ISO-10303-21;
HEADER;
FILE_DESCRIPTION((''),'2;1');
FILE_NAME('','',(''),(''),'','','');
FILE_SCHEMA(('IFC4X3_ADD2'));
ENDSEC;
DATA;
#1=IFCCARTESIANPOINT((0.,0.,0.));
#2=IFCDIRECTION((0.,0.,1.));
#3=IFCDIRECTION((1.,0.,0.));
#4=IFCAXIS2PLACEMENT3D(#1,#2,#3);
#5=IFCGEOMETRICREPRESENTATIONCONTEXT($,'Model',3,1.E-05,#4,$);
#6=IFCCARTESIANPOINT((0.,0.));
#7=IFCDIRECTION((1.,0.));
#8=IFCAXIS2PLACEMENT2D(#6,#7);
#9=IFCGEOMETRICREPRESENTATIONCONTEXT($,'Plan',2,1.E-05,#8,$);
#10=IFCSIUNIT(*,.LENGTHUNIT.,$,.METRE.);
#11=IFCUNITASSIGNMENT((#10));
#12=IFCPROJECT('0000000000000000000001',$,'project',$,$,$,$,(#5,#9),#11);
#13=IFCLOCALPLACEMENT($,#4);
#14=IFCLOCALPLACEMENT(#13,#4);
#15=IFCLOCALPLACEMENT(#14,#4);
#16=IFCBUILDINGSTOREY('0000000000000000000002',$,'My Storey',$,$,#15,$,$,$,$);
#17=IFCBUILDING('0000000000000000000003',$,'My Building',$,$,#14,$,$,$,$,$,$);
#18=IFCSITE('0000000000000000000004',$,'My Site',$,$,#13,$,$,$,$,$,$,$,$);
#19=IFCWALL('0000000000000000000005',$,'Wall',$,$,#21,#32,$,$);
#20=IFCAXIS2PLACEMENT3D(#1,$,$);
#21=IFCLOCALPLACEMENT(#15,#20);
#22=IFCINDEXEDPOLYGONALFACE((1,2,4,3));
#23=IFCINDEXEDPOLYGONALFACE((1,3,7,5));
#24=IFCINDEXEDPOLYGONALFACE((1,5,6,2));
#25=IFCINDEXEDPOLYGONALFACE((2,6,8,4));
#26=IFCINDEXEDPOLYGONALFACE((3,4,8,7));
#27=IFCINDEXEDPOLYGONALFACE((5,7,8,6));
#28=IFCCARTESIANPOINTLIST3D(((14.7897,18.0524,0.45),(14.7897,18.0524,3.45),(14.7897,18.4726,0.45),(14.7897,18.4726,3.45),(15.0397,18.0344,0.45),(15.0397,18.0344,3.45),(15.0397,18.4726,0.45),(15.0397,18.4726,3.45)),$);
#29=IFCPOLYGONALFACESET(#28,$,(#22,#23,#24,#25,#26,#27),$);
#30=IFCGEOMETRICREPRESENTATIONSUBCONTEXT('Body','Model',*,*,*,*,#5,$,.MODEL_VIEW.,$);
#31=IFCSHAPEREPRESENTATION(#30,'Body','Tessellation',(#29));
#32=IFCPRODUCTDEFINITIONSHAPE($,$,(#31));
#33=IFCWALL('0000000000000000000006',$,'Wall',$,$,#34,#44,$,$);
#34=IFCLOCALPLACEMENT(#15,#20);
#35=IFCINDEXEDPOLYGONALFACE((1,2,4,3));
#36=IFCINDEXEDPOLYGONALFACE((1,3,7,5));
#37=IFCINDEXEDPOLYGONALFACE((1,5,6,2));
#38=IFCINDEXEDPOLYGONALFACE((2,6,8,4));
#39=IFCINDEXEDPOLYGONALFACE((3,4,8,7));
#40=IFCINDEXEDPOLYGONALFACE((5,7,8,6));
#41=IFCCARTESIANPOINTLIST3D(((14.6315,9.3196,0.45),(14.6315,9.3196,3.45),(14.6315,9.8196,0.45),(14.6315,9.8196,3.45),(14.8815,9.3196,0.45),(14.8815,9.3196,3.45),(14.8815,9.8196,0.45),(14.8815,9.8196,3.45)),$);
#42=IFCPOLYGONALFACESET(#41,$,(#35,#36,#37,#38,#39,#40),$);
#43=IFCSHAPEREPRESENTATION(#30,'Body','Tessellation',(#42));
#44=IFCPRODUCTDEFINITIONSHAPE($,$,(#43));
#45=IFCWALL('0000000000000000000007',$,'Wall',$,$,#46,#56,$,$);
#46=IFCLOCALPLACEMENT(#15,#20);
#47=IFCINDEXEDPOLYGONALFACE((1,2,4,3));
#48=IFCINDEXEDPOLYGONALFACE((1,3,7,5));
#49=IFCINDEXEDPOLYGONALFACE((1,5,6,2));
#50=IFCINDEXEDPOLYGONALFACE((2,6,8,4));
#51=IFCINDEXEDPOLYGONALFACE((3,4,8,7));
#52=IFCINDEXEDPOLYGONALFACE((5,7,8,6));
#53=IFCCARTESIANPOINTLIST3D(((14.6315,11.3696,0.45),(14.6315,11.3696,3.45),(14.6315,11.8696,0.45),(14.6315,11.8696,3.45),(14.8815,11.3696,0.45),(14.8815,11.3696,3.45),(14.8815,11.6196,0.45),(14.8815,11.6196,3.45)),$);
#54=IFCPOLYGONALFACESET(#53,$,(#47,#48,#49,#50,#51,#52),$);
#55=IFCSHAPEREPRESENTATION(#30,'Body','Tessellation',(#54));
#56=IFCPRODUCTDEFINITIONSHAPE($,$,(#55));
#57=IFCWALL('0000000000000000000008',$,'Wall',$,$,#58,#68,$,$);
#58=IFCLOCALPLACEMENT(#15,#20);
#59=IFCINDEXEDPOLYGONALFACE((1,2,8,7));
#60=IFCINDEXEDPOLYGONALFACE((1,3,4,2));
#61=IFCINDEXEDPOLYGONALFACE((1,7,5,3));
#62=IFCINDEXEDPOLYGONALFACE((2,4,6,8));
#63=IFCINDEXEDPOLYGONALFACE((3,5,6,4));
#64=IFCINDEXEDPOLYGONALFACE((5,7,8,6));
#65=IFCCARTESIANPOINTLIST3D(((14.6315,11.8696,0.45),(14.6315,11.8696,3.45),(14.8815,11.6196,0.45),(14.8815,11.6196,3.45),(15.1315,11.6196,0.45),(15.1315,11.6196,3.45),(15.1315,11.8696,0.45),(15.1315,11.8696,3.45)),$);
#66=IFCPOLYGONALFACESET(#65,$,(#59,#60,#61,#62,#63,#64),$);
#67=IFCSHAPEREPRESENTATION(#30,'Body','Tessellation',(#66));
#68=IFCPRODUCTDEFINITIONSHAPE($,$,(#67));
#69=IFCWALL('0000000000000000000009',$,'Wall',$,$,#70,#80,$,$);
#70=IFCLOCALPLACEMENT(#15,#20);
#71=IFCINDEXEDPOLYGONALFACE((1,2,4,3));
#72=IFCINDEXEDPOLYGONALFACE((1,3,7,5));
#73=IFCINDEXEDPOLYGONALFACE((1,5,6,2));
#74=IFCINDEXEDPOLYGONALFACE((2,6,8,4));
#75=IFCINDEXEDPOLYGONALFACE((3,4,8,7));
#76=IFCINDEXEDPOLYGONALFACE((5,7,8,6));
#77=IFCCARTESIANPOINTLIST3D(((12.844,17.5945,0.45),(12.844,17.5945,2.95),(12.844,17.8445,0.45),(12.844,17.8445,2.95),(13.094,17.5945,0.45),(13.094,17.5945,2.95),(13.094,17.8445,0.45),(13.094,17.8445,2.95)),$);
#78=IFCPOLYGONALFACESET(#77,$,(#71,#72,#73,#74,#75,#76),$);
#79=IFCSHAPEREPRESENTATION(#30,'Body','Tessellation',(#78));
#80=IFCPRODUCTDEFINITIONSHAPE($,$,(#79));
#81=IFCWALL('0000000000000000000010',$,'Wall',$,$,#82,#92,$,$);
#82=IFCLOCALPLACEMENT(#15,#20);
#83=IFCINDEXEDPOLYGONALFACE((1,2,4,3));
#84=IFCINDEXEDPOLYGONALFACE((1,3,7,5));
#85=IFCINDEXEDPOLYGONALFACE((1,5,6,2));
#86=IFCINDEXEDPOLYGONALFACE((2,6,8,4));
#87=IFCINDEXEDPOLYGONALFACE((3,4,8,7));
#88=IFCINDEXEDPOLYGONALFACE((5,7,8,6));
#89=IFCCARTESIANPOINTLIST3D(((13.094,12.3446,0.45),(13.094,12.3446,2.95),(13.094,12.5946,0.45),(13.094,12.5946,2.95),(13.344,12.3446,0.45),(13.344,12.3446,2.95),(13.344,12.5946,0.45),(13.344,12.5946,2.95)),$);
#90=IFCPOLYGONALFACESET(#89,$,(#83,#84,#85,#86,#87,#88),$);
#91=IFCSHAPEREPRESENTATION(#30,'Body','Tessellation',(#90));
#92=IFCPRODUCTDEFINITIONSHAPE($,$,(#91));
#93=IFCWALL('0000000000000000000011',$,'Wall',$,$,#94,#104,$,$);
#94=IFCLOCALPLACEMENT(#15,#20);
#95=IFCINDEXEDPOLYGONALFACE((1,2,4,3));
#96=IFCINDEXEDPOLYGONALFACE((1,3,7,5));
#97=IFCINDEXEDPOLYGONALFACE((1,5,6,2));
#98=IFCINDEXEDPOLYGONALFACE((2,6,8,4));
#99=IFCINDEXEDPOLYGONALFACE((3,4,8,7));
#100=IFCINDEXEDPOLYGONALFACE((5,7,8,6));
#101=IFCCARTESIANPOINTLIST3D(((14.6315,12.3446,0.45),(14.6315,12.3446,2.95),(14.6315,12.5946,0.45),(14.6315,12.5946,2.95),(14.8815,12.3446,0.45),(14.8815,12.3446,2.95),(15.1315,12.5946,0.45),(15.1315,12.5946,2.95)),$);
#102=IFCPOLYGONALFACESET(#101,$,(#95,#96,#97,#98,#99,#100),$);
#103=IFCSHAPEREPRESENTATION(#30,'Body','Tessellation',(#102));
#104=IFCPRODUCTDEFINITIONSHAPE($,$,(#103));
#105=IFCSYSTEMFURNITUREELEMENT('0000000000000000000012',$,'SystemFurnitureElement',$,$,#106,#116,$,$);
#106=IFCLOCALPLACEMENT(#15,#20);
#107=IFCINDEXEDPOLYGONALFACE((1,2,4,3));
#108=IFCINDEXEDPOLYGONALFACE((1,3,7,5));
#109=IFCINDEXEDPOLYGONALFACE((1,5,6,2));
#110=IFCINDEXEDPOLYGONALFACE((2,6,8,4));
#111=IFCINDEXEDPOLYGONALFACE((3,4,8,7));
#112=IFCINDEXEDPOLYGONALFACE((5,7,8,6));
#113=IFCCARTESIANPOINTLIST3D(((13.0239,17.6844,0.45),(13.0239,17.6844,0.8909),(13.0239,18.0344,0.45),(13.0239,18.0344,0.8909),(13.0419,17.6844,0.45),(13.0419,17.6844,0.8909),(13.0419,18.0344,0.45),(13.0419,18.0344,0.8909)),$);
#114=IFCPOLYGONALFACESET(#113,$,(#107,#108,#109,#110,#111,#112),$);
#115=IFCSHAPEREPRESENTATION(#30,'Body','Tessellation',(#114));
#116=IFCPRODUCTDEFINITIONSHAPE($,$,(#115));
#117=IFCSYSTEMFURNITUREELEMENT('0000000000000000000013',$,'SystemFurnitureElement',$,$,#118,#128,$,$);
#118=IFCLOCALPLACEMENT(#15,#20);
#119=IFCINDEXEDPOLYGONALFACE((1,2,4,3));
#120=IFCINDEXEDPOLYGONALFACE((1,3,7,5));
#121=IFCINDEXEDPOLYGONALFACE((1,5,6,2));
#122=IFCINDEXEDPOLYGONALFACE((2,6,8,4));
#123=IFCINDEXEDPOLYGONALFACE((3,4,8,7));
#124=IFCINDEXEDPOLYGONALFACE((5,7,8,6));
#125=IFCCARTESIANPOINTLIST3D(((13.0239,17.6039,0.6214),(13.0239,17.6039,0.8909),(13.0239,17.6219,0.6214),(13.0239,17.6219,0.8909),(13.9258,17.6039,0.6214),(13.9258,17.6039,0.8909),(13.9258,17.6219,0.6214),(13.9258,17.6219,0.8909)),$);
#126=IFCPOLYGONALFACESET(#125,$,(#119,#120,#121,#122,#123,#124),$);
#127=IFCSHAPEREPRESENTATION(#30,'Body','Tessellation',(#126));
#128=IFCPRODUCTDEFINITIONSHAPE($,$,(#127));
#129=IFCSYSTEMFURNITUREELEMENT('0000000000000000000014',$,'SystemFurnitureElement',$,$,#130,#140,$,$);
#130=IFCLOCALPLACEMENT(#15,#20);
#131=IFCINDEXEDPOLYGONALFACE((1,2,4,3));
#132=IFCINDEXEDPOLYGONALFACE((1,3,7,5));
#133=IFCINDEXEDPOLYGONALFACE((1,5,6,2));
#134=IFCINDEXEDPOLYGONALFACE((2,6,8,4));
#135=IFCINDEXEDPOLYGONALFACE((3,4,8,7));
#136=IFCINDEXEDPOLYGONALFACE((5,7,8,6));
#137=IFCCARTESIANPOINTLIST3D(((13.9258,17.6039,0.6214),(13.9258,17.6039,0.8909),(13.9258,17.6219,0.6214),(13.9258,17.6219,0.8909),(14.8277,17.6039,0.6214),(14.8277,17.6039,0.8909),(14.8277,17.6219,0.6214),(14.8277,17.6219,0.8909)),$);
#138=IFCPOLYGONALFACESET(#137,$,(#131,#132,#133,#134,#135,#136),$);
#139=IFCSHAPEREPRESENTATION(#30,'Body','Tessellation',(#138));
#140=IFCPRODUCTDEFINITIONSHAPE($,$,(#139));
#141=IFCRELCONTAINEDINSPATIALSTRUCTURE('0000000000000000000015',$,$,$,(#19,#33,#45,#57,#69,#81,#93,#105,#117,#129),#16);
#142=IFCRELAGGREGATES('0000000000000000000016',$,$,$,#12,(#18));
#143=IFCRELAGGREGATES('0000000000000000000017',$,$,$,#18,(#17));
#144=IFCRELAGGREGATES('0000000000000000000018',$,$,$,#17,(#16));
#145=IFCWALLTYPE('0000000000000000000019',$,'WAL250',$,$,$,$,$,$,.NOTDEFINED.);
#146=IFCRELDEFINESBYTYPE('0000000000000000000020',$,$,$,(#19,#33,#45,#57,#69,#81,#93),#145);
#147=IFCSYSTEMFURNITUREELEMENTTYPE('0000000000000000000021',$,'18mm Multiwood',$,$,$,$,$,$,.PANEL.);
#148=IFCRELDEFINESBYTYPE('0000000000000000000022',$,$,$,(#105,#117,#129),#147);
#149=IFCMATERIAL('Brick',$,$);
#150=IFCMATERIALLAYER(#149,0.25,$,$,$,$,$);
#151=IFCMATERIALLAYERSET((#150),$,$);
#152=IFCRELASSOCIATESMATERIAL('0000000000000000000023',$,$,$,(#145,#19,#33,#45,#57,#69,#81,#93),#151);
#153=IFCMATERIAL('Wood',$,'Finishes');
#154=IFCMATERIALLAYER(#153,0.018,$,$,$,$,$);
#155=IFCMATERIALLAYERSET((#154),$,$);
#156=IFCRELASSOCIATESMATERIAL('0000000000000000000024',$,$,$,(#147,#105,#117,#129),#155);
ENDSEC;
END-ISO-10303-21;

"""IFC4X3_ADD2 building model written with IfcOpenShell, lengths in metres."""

from ifc_helpers import new_model, si_unit, frame, origin_with_axes, origin_2d_with_axis, place, context, subcontext, project, spatial, line, indexed_curve, outline, extrude, material, layer, layer_set, layer_usage, type_object, element, save


model = new_model("IFC4X3_ADD2")

# Units and contexts
model_context = context("Model", 3, precision=1e-05, world=origin_with_axes())
plan_context = context("Plan", 2, precision=1e-05, world=origin_2d_with_axis())
body_context_1 = subcontext(model_context, "Body", "Model", "MODEL_VIEW")
ifc_project = project(units=[si_unit("LENGTHUNIT", "METRE")], contexts=[model_context, plan_context])

# Site, building, storey
site_placement = place(None, origin_with_axes())
site = spatial("IfcSite", under=ifc_project, at=site_placement, Name="My Site")
building_placement = place(site_placement, origin_with_axes())
building = spatial("IfcBuilding", under=site, at=building_placement, Name="My Building")
storey_placement = place(building_placement, origin_with_axes())
storey = spatial("IfcBuildingStorey", under=building, at=storey_placement, Name="My Storey")

# Shared definitions
ifc_material_1 = material(Name="Brick")

# Shared definitions
ifc_layer_1 = layer(ifc_material_1, 0.25)
ifc_layer_set_1 = layer_set([ifc_layer_1])
wall_type_1 = type_object("IfcWallType", Name="WAL250", PredefinedType="NOTDEFINED", material=ifc_layer_set_1)

# Walls
ifc_layer_usage_1 = layer_usage(ifc_layer_set_1, "AXIS2", "NEGATIVE", 0.0)
wall_1_placement = place(storey_placement, frame((14.7897, 18.0344, 0.45), z_axis=(0.0, 0.0, 1.0), x_axis=(-0.000005, 1.0, 0.0)))
element("IfcWall", 1, at=wall_1_placement, inside=storey, type_object=wall_type_1, material=ifc_layer_usage_1, Name="Wall", context=body_context_1, shape_type="SweptSolid", body=[
    extrude(outline(indexed_curve([(0.0, -0.25), (0.018, 0.0), (0.4382, 0.0), (0.4382, -0.25)], segments=[line(1, 2, 3, 4, 1)])), origin_with_axes(), (0.0, 0.0, 1.0), 3.0),
])
ifc_layer_usage_2 = layer_usage(ifc_layer_set_1, "AXIS2", "NEGATIVE", 0.0)
wall_2_placement = place(storey_placement, frame((14.6315, 9.3196, 0.45), z_axis=(0.0, 0.0, 1.0), x_axis=(-0.000005, 1.0, 0.0)))
element("IfcWall", 2, at=wall_2_placement, inside=storey, type_object=wall_type_1, material=ifc_layer_usage_2, Name="Wall", context=body_context_1, shape_type="SweptSolid", body=[
    extrude(outline(indexed_curve([(0.0, -0.25), (0.0, 0.0), (0.5, 0.0), (0.5, -0.25)], segments=[line(1, 2, 3, 4, 1)])), origin_with_axes(), (0.0, 0.0, 1.0), 3.0),
])
ifc_layer_usage_3 = layer_usage(ifc_layer_set_1, "AXIS2", "NEGATIVE", 0.0)
wall_3_placement = place(storey_placement, frame((14.6315, 11.3696, 0.45), z_axis=(0.0, 0.0, 1.0), x_axis=(-0.000005, 1.0, 0.0)))
element("IfcWall", 3, at=wall_3_placement, inside=storey, type_object=wall_type_1, material=ifc_layer_usage_3, Name="Wall", context=body_context_1, shape_type="SweptSolid", body=[
    extrude(outline(indexed_curve([(0.0, -0.25), (0.0, 0.0), (0.5, 0.0), (0.25, -0.25)], segments=[line(1, 2, 3, 4, 1)])), origin_with_axes(), (0.0, 0.0, 1.0), 3.0),
])
ifc_layer_usage_4 = layer_usage(ifc_layer_set_1, "AXIS2", "NEGATIVE", 0.0)
wall_4_placement = place(storey_placement, frame((14.6315, 11.8696, 0.45), z_axis=(0.0, 0.0, 1.0), x_axis=(1.0, 0.000005, 0.0)))
element("IfcWall", 4, at=wall_4_placement, inside=storey, type_object=wall_type_1, material=ifc_layer_usage_4, Name="Wall", context=body_context_1, shape_type="SweptSolid", body=[
    extrude(outline(indexed_curve([(0.25, -0.25), (0.0, 0.0), (0.5, 0.0), (0.5, -0.25)], segments=[line(1, 2, 3, 4, 1)])), origin_with_axes(), (0.0, 0.0, 1.0), 3.0),
])
ifc_layer_usage_5 = layer_usage(ifc_layer_set_1, "AXIS2", "POSITIVE", 0.0)
wall_5_placement = place(storey_placement, frame((13.094, 17.5945, 0.45), z_axis=(0.0, 0.0, 1.0), x_axis=(-0.000005, 1.0, 0.0)))
element("IfcWall", 5, at=wall_5_placement, inside=storey, type_object=wall_type_1, material=ifc_layer_usage_5, Name="Wall", context=body_context_1, shape_type="SweptSolid", body=[
    extrude(outline(indexed_curve([(0.0, 0.0), (0.0, 0.25), (0.25, 0.25), (0.25, 0.0)], segments=[line(1, 2, 3, 4, 1)])), origin_with_axes(), (0.0, 0.0, 1.0), 2.5),
])
ifc_layer_usage_6 = layer_usage(ifc_layer_set_1, "AXIS2", "NEGATIVE", 0.0)
wall_6_placement = place(storey_placement, frame((13.094, 12.5946, 0.45), z_axis=(0.0, 0.0, 1.0), x_axis=(1.0, 0.000005, 0.0)))
element("IfcWall", 6, at=wall_6_placement, inside=storey, type_object=wall_type_1, material=ifc_layer_usage_6, Name="Wall", context=body_context_1, shape_type="SweptSolid", body=[
    extrude(outline(indexed_curve([(0.0, -0.25), (0.0, 0.0), (0.25, 0.0), (0.25, -0.25)], segments=[line(1, 2, 3, 4, 1)])), origin_with_axes(), (0.0, 0.0, 1.0), 2.5),
])
ifc_layer_usage_7 = layer_usage(ifc_layer_set_1, "AXIS2", "NEGATIVE", 0.0)
wall_7_placement = place(storey_placement, frame((14.6315, 12.5946, 0.45), z_axis=(0.0, 0.0, 1.0), x_axis=(1.0, 0.000005, 0.0)))
element("IfcWall", 7, at=wall_7_placement, inside=storey, type_object=wall_type_1, material=ifc_layer_usage_7, Name="Wall", context=body_context_1, shape_type="SweptSolid", body=[
    extrude(outline(indexed_curve([(0.0, -0.25), (0.0, 0.0), (0.5, 0.0), (0.25, -0.25)], segments=[line(1, 2, 3, 4, 1)])), origin_with_axes(), (0.0, 0.0, 1.0), 2.5),
])

# System furniture elements
ifc_material_2 = material(Name="Wood", Category="Finishes")
ifc_layer_2 = layer(ifc_material_2, 0.018)
ifc_layer_set_2 = layer_set([ifc_layer_2])
ifc_layer_usage_8 = layer_usage(ifc_layer_set_2, "AXIS2", "POSITIVE", 0.0)
system_furniture_element_type = type_object("IfcSystemFurnitureElementType", Name="18mm Multiwood", PredefinedType="PANEL", material=ifc_layer_set_2)
system_furniture_element_1_placement = place(storey_placement, frame((13.0239, 18.0344, 0.45), z_axis=(0.0, 0.0, 1.0), x_axis=(0.0, -1.0, 0.0)))
element("IfcSystemFurnitureElement", 8, at=system_furniture_element_1_placement, inside=storey, type_object=system_furniture_element_type, material=ifc_layer_usage_8, Name="SystemFurnitureElement", context=body_context_1, shape_type="SweptSolid", body=[
    extrude(outline(indexed_curve([(0.0, 0.0), (0.0, 0.018), (0.35, 0.018), (0.35, 0.0)], segments=[line(1, 2, 3, 4, 1)])), origin_with_axes(), (0.0, 0.0, 1.0), 0.4409),
])
ifc_layer_usage_9 = layer_usage(ifc_layer_set_2, "AXIS2", "POSITIVE", 0.0)
system_furniture_element_2_placement = place(storey_placement, frame((13.0239, 17.6039, 0.6214), z_axis=(0.0, 0.0, 1.0), x_axis=(1.0, 0.0, 0.0)))
element("IfcSystemFurnitureElement", 9, at=system_furniture_element_2_placement, inside=storey, type_object=system_furniture_element_type, material=ifc_layer_usage_9, Name="SystemFurnitureElement", context=body_context_1, shape_type="SweptSolid", body=[
    extrude(outline(indexed_curve([(0.0, 0.0), (0.0, 0.018), (0.9019, 0.018), (0.9019, 0.0)], segments=[line(1, 2, 3, 4, 1)])), origin_with_axes(), (0.0, 0.0, 1.0), 0.2695),
])
ifc_layer_usage_10 = layer_usage(ifc_layer_set_2, "AXIS2", "POSITIVE", 0.0)
system_furniture_element_3_placement = place(storey_placement, frame((13.9258, 17.6039, 0.6214), z_axis=(0.0, 0.0, 1.0), x_axis=(1.0, 0.0, 0.0)))
element("IfcSystemFurnitureElement", 10, at=system_furniture_element_3_placement, inside=storey, type_object=system_furniture_element_type, material=ifc_layer_usage_10, Name="SystemFurnitureElement", context=body_context_1, shape_type="SweptSolid", body=[
    extrude(outline(indexed_curve([(0.0, 0.0), (0.0, 0.018), (0.9019, 0.018), (0.9019, 0.0)], segments=[line(1, 2, 3, 4, 1)])), origin_with_axes(), (0.0, 0.0, 1.0), 0.2695),
])

save(model, "model.ifc")
